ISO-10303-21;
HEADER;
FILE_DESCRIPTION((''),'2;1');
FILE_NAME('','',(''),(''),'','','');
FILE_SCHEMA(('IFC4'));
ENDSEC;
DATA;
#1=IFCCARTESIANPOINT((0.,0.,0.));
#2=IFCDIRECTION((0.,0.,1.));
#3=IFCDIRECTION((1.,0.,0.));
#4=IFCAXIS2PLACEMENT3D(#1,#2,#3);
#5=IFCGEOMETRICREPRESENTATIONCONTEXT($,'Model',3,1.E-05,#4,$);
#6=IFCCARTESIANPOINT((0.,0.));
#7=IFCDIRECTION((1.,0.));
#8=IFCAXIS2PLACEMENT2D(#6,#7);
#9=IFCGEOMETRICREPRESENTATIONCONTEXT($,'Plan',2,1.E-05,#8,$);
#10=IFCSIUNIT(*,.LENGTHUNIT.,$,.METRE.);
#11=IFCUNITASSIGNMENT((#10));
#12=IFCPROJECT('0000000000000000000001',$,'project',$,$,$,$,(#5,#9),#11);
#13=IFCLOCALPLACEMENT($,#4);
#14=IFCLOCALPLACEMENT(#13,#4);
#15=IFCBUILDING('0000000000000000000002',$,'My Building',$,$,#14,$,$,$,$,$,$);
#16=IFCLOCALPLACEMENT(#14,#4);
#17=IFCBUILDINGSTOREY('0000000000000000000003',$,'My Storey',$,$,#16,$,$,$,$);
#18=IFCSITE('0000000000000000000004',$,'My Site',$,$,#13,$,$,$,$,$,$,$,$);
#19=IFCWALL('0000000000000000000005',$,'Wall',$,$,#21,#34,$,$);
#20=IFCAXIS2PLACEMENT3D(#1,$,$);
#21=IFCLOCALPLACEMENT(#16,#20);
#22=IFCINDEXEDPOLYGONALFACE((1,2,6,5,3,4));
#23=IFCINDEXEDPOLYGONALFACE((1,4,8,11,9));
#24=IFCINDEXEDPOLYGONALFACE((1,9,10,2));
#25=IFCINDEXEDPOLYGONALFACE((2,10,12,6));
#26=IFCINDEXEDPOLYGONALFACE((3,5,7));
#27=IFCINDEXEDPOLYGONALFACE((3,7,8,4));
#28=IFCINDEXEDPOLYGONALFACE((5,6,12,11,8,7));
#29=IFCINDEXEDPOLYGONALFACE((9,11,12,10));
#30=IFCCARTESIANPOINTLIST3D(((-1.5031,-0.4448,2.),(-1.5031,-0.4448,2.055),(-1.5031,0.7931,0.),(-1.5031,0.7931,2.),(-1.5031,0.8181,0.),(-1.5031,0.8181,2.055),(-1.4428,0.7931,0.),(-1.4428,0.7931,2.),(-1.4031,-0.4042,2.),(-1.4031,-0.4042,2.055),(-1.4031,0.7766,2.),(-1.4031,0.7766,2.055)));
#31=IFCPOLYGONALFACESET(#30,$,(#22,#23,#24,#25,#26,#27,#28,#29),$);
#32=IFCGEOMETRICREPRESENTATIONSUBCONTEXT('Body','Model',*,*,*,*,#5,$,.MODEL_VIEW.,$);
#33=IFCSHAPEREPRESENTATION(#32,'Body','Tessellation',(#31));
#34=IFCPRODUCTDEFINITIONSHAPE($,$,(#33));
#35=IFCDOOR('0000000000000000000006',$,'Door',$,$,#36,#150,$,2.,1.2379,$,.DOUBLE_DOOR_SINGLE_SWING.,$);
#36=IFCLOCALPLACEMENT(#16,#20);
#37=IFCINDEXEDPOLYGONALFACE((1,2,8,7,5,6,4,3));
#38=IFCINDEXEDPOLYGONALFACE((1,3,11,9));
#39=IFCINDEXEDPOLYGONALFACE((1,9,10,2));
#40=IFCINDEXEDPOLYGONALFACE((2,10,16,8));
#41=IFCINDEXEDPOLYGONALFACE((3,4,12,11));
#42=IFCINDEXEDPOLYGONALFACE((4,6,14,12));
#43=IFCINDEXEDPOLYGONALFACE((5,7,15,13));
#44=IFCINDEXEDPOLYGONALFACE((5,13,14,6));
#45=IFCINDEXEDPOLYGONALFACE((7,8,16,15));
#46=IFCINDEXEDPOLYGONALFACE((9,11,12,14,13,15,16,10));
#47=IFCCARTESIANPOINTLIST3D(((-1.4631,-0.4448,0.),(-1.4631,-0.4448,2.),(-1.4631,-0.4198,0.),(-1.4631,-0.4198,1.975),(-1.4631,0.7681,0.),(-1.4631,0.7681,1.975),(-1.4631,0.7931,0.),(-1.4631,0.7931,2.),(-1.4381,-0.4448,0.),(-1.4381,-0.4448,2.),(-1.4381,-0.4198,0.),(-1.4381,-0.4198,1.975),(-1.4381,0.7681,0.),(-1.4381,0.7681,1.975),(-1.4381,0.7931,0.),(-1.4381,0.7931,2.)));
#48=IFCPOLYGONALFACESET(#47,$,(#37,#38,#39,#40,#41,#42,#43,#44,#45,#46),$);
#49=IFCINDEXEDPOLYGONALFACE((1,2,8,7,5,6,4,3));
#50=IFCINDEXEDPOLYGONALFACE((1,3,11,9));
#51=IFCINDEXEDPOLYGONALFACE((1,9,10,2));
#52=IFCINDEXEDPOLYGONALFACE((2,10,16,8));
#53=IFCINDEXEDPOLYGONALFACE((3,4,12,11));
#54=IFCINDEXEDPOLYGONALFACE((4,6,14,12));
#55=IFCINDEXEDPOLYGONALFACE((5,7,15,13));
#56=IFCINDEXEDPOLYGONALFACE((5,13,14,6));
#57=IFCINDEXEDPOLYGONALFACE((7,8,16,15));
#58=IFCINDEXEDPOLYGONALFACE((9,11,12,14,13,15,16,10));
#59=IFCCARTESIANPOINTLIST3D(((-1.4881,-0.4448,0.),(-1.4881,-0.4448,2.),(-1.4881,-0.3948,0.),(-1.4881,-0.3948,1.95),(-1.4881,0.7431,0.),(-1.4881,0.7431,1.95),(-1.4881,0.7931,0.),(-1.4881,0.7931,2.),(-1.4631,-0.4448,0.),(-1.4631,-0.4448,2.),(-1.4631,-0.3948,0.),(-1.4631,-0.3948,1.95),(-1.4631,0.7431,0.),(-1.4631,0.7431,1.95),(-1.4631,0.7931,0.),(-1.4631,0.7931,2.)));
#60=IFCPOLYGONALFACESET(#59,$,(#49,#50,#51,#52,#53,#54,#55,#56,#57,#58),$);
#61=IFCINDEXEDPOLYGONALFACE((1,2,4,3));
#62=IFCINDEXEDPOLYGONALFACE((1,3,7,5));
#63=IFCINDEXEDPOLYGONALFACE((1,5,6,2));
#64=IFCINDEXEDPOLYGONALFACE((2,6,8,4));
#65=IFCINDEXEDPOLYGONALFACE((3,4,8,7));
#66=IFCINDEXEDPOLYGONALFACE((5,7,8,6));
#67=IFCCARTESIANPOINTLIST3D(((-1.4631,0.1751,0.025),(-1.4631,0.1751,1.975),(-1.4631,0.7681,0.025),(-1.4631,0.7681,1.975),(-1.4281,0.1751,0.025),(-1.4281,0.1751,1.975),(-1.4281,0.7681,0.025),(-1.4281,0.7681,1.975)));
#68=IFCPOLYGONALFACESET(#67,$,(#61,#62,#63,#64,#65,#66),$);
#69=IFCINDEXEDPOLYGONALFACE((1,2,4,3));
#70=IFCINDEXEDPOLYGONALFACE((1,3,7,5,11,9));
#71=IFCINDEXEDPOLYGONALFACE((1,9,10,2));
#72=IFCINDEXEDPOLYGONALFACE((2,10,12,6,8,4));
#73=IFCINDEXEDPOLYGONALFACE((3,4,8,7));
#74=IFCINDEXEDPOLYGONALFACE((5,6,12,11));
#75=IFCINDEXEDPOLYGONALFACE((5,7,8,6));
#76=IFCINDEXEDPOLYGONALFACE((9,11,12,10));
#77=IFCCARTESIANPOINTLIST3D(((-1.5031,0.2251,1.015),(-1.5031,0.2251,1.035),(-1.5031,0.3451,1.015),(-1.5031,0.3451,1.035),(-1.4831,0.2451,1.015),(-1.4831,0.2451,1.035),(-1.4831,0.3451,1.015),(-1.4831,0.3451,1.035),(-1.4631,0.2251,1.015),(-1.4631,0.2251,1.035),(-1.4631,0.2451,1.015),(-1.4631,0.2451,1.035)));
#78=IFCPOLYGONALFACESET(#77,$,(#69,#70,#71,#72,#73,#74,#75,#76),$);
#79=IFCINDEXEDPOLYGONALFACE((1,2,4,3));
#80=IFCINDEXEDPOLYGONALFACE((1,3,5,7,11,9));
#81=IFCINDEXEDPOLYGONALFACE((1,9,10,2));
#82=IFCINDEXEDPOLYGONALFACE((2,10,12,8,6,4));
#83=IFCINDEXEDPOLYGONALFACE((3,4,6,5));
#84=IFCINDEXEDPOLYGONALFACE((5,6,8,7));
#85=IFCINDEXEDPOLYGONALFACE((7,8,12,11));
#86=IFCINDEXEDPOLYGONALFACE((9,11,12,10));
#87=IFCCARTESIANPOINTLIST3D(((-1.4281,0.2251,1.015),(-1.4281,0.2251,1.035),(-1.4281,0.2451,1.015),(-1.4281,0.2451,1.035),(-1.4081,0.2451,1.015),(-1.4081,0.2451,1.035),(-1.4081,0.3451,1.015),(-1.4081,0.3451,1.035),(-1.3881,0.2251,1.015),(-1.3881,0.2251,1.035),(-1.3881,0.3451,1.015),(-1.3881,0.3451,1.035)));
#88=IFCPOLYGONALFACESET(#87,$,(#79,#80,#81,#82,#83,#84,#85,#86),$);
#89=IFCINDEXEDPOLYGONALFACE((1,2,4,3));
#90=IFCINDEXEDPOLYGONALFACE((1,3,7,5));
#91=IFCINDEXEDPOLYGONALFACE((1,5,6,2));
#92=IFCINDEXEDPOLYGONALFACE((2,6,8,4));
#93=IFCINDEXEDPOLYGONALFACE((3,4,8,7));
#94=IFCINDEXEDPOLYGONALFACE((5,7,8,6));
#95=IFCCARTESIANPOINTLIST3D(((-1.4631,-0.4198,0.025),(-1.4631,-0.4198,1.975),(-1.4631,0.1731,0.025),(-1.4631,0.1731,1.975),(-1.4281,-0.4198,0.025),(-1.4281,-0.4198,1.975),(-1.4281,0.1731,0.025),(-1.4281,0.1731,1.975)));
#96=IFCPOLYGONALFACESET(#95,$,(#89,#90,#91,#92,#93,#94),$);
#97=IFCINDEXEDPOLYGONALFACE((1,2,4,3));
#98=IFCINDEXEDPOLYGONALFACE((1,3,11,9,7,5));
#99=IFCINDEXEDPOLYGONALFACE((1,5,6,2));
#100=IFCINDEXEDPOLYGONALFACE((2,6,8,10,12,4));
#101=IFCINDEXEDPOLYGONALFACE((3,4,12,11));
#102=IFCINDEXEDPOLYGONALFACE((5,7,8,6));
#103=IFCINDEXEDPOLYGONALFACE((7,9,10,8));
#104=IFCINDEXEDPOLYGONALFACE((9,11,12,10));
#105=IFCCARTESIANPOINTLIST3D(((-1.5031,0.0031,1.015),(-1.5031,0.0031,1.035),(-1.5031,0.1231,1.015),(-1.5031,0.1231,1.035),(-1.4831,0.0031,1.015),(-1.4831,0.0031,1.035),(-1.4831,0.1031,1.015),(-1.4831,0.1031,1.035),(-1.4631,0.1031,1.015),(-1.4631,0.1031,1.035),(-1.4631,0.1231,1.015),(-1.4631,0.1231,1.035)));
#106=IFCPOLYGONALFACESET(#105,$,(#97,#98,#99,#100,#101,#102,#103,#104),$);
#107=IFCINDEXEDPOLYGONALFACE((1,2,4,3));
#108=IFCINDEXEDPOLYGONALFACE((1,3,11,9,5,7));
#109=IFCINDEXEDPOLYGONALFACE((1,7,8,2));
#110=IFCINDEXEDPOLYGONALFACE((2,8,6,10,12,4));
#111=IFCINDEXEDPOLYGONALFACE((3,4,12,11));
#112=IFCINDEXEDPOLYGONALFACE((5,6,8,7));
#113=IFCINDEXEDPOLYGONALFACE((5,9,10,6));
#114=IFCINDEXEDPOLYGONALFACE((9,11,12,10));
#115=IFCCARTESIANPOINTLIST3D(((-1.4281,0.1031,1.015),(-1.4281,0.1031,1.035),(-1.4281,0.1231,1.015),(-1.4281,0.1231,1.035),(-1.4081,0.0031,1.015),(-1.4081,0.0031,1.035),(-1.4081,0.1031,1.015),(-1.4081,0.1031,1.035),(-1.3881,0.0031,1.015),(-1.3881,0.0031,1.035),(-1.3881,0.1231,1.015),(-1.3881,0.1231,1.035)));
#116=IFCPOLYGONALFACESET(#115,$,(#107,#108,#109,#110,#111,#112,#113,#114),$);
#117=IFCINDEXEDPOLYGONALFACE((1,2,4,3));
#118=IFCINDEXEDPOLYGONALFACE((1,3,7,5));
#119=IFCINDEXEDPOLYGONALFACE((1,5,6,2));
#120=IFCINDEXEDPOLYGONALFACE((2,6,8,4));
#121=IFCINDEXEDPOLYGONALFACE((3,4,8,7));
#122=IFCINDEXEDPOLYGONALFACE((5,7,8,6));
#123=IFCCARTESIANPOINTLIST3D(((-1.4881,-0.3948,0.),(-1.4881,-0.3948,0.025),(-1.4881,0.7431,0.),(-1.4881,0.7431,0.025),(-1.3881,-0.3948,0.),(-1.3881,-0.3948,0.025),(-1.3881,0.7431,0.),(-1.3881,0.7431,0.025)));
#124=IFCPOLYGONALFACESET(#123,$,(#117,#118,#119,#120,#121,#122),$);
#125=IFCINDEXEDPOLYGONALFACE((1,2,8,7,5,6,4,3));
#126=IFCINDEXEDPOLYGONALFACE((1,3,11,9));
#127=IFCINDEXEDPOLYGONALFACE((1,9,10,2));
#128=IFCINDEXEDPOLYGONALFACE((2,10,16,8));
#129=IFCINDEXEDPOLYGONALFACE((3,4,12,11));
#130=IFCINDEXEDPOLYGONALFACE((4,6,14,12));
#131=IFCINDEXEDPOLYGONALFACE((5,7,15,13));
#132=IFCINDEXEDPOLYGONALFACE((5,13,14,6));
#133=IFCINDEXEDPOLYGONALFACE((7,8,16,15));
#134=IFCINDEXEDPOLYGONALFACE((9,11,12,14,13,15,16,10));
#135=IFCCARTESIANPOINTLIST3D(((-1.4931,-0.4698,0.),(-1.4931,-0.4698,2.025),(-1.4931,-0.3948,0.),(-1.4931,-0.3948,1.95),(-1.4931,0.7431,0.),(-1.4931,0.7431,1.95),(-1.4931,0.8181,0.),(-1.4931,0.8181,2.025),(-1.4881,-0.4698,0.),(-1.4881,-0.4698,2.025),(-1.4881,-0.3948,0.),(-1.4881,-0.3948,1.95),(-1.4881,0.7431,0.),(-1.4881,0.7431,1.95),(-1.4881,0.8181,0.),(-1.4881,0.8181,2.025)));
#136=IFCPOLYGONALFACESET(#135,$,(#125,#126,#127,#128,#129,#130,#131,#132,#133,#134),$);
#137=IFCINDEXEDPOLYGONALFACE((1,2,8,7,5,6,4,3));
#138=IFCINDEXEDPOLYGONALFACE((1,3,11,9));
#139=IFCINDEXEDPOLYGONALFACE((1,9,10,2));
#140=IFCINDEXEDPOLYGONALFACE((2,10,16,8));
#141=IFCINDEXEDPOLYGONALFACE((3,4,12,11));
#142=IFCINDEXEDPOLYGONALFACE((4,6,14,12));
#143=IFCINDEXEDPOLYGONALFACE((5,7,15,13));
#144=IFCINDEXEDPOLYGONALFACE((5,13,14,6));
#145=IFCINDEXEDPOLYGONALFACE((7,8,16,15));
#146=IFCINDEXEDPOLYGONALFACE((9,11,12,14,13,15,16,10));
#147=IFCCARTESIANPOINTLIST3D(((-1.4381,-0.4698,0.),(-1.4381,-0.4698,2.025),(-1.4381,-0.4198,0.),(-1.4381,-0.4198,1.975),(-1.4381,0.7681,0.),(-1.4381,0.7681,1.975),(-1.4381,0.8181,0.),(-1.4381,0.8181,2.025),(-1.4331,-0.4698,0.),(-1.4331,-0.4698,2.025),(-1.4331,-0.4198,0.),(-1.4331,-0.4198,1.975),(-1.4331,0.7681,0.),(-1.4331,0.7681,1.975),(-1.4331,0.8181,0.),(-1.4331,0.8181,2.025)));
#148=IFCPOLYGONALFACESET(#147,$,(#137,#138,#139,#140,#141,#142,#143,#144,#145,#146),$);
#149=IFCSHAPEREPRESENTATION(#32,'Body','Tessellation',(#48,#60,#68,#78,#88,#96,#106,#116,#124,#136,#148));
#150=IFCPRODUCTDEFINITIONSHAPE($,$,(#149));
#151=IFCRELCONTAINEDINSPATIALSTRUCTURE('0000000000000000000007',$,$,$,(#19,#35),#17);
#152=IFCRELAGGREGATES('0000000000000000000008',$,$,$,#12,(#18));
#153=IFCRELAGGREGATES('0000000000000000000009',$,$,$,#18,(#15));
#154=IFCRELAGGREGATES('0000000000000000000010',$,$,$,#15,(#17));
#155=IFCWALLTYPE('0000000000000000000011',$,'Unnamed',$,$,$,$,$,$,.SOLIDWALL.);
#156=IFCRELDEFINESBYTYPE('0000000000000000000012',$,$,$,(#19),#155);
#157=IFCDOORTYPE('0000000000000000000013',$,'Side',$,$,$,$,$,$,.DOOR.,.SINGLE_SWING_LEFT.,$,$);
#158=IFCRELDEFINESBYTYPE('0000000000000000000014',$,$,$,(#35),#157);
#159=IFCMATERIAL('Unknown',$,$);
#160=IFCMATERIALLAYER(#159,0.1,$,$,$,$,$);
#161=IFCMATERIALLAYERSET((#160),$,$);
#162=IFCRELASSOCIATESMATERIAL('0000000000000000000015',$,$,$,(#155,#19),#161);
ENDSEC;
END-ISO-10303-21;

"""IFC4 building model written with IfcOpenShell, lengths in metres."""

from ifc_helpers import new_model, entity, si_unit, frame, origin_with_axes, origin_2d_with_axis, place, context, subcontext, project, spatial, line, indexed_curve, outline, extrude, shape, source, transform, mapped, material, layer, layer_set, layer_usage, type_object, type_shapes, element, fill, save


model = new_model("IFC4")

# Units and contexts
model_context = context("Model", 3, precision=1e-05, world=origin_with_axes())
plan_context = context("Plan", 2, precision=1e-05, world=origin_2d_with_axis())
body_context_1 = subcontext(model_context, "Body", "Model", "MODEL_VIEW")
body_context_2 = subcontext(plan_context, "Body", "Plan", "PLAN_VIEW")
ifc_project = project(units=[si_unit("LENGTHUNIT", "METRE")], contexts=[model_context, plan_context])

# Site, building, storey
site_placement = place(None, origin_with_axes())
site = spatial("IfcSite", under=ifc_project, at=site_placement, Name="My Site")
building_placement = place(site_placement, origin_with_axes())
building = spatial("IfcBuilding", under=site, at=building_placement, Name="My Building")
storey_placement = place(building_placement, origin_with_axes())
storey = spatial("IfcBuildingStorey", under=building, at=storey_placement, Name="My Storey")

# Shared definitions
ifc_material = material(Name="Unknown")

# Shared definitions
ifc_layer_1 = layer(ifc_material, 0.1)
ifc_layer_set_1 = layer_set([ifc_layer_1])
wall_type = type_object("IfcWallType", Name="Unnamed", PredefinedType="SOLIDWALL", material=ifc_layer_set_1)

# Wall, opening, door
ifc_layer_usage_1 = layer_usage(ifc_layer_set_1, "AXIS2", "POSITIVE", 0.0)
wall_1_placement = place(storey_placement, frame((-1.5031, 0.8181, 0.0), z_axis=(0.0, 0.0, 1.0), x_axis=(0.0, -1.0, 0.0)))
wall_1 = element("IfcWall", 1, at=wall_1_placement, inside=storey, type_object=wall_type, material=ifc_layer_usage_1, Name="Wall", context=body_context_1, shape_type="SweptSolid", body=[
    extrude(outline(indexed_curve([(0.0, 0.0), (0.0414, 0.1), (1.2222, 0.1), (1.2629, 0.0)], segments=[line(1, 2, 3, 4, 1)])), origin_with_axes(), (0.0, 0.0, 1.0), 2.055),
])
shared_shape_1 = source(origin_with_axes(), body_context_1, "Body", "SweptSolid", [
    extrude(outline(indexed_curve([(0.0, 0.0), (1.2379, 0.0), (1.2379, 2.0), (0.0, 2.0)], segments=[line(1, 2, 3, 4, 1)])), frame((0.0, -0.6, 0.0), z_axis=(0.0, -1.0, 0.0), x_axis=(1.0, 0.0, 0.0)), (0.0, 0.0, -1.0), 1.2),
])
opening_1_placement = place(wall_1_placement, frame((0.025, 0.015, 0.0), z_axis=(0.0, 0.0, 1.0), x_axis=(1.0, 0.0, 0.0)))
opening_1 = element("IfcOpeningElement", 2, at=opening_1_placement, cuts=wall_1, PredefinedType="OPENING", context=body_context_1, shape_type="MappedRepresentation", body=[
    mapped(shared_shape_1, transform((0.0, 0.0, 0.0), x_axis=(1.0, 0.0, 0.0), y_axis=(0.0, 1.0, 0.0), z_axis=(0.0, 0.0, 1.0), scale=1.0)),
])
door_type_1 = type_object("IfcDoorType", Name="Side", OperationType="SINGLE_SWING_LEFT", PredefinedType="DOOR")
shared_shape_2 = source(origin_with_axes(), body_context_1, "Body", "SweptSolid", [
    extrude(outline(indexed_curve([(0.0, 0.0), (0.0, 2.0), (1.2379, 2.0), (1.2379, 0.0), (1.2129, 0.0), (1.2129, 1.975), (0.025, 1.975), (0.025, 0.0)], segments=[line(1, 2, 3, 4, 5, 6, 7, 8, 1)])), frame((0.0, 0.025, 0.0), z_axis=(0.0, -1.0, 0.0), x_axis=(1.0, 0.0, 0.0)), (0.0, 0.0, -1.0), 0.025),
    extrude(outline(indexed_curve([(0.0, 0.0), (0.0, 2.0), (1.2379, 2.0), (1.2379, 0.0), (1.1879, 0.0), (1.1879, 1.95), (0.05, 1.95), (0.05, 0.0)], segments=[line(1, 2, 3, 4, 5, 6, 7, 8, 1)])), frame((0.0, 0.0, 0.0), z_axis=(0.0, -1.0, 0.0), x_axis=(1.0, 0.0, 0.0)), (0.0, 0.0, -1.0), 0.025),
    extrude(outline(indexed_curve([(0.0, 0.0), (0.5929, 0.0), (0.5929, 0.035), (0.0, 0.035)], segments=[line(1, 2, 3, 4, 1)])), frame((0.025, 0.025, 0.025), z_axis=(0.0, 0.0, 1.0), x_axis=(1.0, 0.0, 0.0)), (0.0, 0.0, 1.0), 1.95),
    extrude(outline(indexed_curve([(0.0, 0.0), (0.0, -0.04), (-0.12, -0.04), (-0.12, -0.02), (-0.02, -0.02), (-0.02, 0.0)], segments=[line(1, 2, 3, 4, 5, 6, 1)])), frame((0.5679, 0.025, 1.015), z_axis=(0.0, 0.0, 1.0), x_axis=(1.0, 0.0, 0.0)), (0.0, 0.0, 1.0), 0.02),
    extrude(outline(indexed_curve([(0.0, 0.0), (0.0, 0.04), (-0.12, 0.04), (-0.12, 0.02), (-0.02, 0.02), (-0.02, 0.0)], segments=[line(1, 2, 3, 4, 5, 6, 1)])), frame((0.5679, 0.06, 1.015), z_axis=(0.0, 0.0, 1.0), x_axis=(1.0, 0.0, 0.0)), (0.0, 0.0, 1.0), 0.02),
    extrude(outline(indexed_curve([(0.0, 0.0), (-0.5929, 0.0), (-0.5929, 0.035), (0.0, 0.035)], segments=[line(1, 2, 3, 4, 1)])), frame((1.2129, 0.025, 0.025), z_axis=(0.0, 0.0, 1.0), x_axis=(1.0, 0.0, 0.0)), (0.0, 0.0, 1.0), 1.95),
    extrude(outline(indexed_curve([(0.0, 0.0), (0.0, -0.04), (0.12, -0.04), (0.12, -0.02), (0.02, -0.02), (0.02, 0.0)], segments=[line(1, 2, 3, 4, 5, 6, 1)])), frame((0.6699, 0.025, 1.015), z_axis=(0.0, 0.0, 1.0), x_axis=(1.0, 0.0, 0.0)), (0.0, 0.0, 1.0), 0.02),
    extrude(outline(indexed_curve([(0.0, 0.0), (0.0, 0.04), (0.12, 0.04), (0.12, 0.02), (0.02, 0.02), (0.02, 0.0)], segments=[line(1, 2, 3, 4, 5, 6, 1)])), frame((0.6699, 0.06, 1.015), z_axis=(0.0, 0.0, 1.0), x_axis=(1.0, 0.0, 0.0)), (0.0, 0.0, 1.0), 0.02),
    extrude(outline(indexed_curve([(0.0, 0.0), (1.1379, 0.0), (1.1379, 0.1), (0.0, 0.1)], segments=[line(1, 2, 3, 4, 1)])), frame((0.05, 0.0, 0.0), z_axis=(0.0, 0.0, 1.0), x_axis=(1.0, 0.0, 0.0)), (0.0, 0.0, 1.0), 0.025),
    extrude(outline(indexed_curve([(0.0, 0.0), (0.0, 2.025), (1.2879, 2.025), (1.2879, 0.0), (1.2129, 0.0), (1.2129, 1.95), (0.075, 1.95), (0.075, 0.0)], segments=[line(1, 2, 3, 4, 5, 6, 7, 8, 1)])), frame((-0.025, -0.005, 0.0), z_axis=(0.0, -1.0, 0.0), x_axis=(1.0, 0.0, 0.0)), (0.0, 0.0, -1.0), 0.005),
    extrude(outline(indexed_curve([(0.0, 0.0), (0.0, 2.025), (1.2879, 2.025), (1.2879, 0.0), (1.2379, 0.0), (1.2379, 1.975), (0.05, 1.975), (0.05, 0.0)], segments=[line(1, 2, 3, 4, 5, 6, 7, 8, 1)])), frame((-0.025, 0.05, 0.0), z_axis=(0.0, -1.0, 0.0), x_axis=(1.0, 0.0, 0.0)), (0.0, 0.0, -1.0), 0.005),
])
shared_shape_3 = source(origin_with_axes(), body_context_2, "Body", "Curve2D", [
    entity("IfcIndexedPolyCurve", entity("IfcCartesianPointList2D", [[0.0, 0.0], [0.0, 0.05], [0.025, 0.05], [0.025, 0.025], [0.05, 0.025], [0.05, 0.0]]), [entity("IfcLineIndex", [1, 2, 3, 4, 5, 6, 1])]),
    entity("IfcIndexedPolyCurve", entity("IfcCartesianPointList2D", [[1.2379, 0.0], [1.2379, 0.05], [1.2129, 0.05], [1.2129, 0.025], [1.1879, 0.025], [1.1879, 0.0]]), [entity("IfcLineIndex", [1, 2, 3, 4, 5, 6, 1])]),
    entity("IfcTrimmedCurve", entity("IfcEllipse", entity("IfcAxis2Placement2D", entity("IfcCartesianPoint", [0.06, 0.05]), entity("IfcDirection", [1.0, 0.0])), 0.5589, 0.5939), [entity("IfcCartesianPoint", [0.6189, 0.05])], [entity("IfcCartesianPoint", [0.06, 0.6439])], True, "CARTESIAN"),
    entity("IfcIndexedPolyCurve", entity("IfcCartesianPointList2D", [[0.025, 0.05], [0.06, 0.05], [0.06, 0.6439], [0.025, 0.6439]]), [entity("IfcLineIndex", [1, 2, 3, 4, 1])]),
    entity("IfcTrimmedCurve", entity("IfcEllipse", entity("IfcAxis2Placement2D", entity("IfcCartesianPoint", [1.1779, 0.05]), entity("IfcDirection", [1.0, 0.0])), 0.5589, 0.5939), [entity("IfcCartesianPoint", [1.1779, 0.6439])], [entity("IfcCartesianPoint", [0.6189, 0.05])], True, "CARTESIAN"),
    entity("IfcIndexedPolyCurve", entity("IfcCartesianPointList2D", [[1.2129, 0.05], [1.1779, 0.05], [1.1779, 0.6439], [1.2129, 0.6439]]), [entity("IfcLineIndex", [1, 2, 3, 4, 1])]),
])
type_shapes(door_type_1, [shared_shape_2, shared_shape_3])
door_1_placement = place(opening_1_placement, frame((0.0, 0.0, 0.0), z_axis=(0.0, 0.0, 1.0), x_axis=(1.0, 0.0, 0.0)))
door_1 = element("IfcDoor", 3, at=door_1_placement, inside=storey, type_object=door_type_1, Name="Door", OperationType="DOUBLE_DOOR_SINGLE_SWING", OverallHeight=2.0, OverallWidth=1.2379, shapes=[
    shape(body_context_1, "Body", "MappedRepresentation", [mapped(shared_shape_2, transform((0.0, 0.0, 0.0), x_axis=(1.0, 0.0, 0.0), y_axis=(0.0, 1.0, 0.0), z_axis=(0.0, 0.0, 1.0), scale=1.0))]),
    shape(body_context_2, "Body", "MappedRepresentation", [mapped(shared_shape_3, transform((0.0, 0.0, 0.0), x_axis=(1.0, 0.0, 0.0), y_axis=(0.0, 1.0, 0.0), z_axis=(0.0, 0.0, 1.0), scale=1.0))]),
])
fill(opening_1, door_1)

save(model, "model.ifc")
